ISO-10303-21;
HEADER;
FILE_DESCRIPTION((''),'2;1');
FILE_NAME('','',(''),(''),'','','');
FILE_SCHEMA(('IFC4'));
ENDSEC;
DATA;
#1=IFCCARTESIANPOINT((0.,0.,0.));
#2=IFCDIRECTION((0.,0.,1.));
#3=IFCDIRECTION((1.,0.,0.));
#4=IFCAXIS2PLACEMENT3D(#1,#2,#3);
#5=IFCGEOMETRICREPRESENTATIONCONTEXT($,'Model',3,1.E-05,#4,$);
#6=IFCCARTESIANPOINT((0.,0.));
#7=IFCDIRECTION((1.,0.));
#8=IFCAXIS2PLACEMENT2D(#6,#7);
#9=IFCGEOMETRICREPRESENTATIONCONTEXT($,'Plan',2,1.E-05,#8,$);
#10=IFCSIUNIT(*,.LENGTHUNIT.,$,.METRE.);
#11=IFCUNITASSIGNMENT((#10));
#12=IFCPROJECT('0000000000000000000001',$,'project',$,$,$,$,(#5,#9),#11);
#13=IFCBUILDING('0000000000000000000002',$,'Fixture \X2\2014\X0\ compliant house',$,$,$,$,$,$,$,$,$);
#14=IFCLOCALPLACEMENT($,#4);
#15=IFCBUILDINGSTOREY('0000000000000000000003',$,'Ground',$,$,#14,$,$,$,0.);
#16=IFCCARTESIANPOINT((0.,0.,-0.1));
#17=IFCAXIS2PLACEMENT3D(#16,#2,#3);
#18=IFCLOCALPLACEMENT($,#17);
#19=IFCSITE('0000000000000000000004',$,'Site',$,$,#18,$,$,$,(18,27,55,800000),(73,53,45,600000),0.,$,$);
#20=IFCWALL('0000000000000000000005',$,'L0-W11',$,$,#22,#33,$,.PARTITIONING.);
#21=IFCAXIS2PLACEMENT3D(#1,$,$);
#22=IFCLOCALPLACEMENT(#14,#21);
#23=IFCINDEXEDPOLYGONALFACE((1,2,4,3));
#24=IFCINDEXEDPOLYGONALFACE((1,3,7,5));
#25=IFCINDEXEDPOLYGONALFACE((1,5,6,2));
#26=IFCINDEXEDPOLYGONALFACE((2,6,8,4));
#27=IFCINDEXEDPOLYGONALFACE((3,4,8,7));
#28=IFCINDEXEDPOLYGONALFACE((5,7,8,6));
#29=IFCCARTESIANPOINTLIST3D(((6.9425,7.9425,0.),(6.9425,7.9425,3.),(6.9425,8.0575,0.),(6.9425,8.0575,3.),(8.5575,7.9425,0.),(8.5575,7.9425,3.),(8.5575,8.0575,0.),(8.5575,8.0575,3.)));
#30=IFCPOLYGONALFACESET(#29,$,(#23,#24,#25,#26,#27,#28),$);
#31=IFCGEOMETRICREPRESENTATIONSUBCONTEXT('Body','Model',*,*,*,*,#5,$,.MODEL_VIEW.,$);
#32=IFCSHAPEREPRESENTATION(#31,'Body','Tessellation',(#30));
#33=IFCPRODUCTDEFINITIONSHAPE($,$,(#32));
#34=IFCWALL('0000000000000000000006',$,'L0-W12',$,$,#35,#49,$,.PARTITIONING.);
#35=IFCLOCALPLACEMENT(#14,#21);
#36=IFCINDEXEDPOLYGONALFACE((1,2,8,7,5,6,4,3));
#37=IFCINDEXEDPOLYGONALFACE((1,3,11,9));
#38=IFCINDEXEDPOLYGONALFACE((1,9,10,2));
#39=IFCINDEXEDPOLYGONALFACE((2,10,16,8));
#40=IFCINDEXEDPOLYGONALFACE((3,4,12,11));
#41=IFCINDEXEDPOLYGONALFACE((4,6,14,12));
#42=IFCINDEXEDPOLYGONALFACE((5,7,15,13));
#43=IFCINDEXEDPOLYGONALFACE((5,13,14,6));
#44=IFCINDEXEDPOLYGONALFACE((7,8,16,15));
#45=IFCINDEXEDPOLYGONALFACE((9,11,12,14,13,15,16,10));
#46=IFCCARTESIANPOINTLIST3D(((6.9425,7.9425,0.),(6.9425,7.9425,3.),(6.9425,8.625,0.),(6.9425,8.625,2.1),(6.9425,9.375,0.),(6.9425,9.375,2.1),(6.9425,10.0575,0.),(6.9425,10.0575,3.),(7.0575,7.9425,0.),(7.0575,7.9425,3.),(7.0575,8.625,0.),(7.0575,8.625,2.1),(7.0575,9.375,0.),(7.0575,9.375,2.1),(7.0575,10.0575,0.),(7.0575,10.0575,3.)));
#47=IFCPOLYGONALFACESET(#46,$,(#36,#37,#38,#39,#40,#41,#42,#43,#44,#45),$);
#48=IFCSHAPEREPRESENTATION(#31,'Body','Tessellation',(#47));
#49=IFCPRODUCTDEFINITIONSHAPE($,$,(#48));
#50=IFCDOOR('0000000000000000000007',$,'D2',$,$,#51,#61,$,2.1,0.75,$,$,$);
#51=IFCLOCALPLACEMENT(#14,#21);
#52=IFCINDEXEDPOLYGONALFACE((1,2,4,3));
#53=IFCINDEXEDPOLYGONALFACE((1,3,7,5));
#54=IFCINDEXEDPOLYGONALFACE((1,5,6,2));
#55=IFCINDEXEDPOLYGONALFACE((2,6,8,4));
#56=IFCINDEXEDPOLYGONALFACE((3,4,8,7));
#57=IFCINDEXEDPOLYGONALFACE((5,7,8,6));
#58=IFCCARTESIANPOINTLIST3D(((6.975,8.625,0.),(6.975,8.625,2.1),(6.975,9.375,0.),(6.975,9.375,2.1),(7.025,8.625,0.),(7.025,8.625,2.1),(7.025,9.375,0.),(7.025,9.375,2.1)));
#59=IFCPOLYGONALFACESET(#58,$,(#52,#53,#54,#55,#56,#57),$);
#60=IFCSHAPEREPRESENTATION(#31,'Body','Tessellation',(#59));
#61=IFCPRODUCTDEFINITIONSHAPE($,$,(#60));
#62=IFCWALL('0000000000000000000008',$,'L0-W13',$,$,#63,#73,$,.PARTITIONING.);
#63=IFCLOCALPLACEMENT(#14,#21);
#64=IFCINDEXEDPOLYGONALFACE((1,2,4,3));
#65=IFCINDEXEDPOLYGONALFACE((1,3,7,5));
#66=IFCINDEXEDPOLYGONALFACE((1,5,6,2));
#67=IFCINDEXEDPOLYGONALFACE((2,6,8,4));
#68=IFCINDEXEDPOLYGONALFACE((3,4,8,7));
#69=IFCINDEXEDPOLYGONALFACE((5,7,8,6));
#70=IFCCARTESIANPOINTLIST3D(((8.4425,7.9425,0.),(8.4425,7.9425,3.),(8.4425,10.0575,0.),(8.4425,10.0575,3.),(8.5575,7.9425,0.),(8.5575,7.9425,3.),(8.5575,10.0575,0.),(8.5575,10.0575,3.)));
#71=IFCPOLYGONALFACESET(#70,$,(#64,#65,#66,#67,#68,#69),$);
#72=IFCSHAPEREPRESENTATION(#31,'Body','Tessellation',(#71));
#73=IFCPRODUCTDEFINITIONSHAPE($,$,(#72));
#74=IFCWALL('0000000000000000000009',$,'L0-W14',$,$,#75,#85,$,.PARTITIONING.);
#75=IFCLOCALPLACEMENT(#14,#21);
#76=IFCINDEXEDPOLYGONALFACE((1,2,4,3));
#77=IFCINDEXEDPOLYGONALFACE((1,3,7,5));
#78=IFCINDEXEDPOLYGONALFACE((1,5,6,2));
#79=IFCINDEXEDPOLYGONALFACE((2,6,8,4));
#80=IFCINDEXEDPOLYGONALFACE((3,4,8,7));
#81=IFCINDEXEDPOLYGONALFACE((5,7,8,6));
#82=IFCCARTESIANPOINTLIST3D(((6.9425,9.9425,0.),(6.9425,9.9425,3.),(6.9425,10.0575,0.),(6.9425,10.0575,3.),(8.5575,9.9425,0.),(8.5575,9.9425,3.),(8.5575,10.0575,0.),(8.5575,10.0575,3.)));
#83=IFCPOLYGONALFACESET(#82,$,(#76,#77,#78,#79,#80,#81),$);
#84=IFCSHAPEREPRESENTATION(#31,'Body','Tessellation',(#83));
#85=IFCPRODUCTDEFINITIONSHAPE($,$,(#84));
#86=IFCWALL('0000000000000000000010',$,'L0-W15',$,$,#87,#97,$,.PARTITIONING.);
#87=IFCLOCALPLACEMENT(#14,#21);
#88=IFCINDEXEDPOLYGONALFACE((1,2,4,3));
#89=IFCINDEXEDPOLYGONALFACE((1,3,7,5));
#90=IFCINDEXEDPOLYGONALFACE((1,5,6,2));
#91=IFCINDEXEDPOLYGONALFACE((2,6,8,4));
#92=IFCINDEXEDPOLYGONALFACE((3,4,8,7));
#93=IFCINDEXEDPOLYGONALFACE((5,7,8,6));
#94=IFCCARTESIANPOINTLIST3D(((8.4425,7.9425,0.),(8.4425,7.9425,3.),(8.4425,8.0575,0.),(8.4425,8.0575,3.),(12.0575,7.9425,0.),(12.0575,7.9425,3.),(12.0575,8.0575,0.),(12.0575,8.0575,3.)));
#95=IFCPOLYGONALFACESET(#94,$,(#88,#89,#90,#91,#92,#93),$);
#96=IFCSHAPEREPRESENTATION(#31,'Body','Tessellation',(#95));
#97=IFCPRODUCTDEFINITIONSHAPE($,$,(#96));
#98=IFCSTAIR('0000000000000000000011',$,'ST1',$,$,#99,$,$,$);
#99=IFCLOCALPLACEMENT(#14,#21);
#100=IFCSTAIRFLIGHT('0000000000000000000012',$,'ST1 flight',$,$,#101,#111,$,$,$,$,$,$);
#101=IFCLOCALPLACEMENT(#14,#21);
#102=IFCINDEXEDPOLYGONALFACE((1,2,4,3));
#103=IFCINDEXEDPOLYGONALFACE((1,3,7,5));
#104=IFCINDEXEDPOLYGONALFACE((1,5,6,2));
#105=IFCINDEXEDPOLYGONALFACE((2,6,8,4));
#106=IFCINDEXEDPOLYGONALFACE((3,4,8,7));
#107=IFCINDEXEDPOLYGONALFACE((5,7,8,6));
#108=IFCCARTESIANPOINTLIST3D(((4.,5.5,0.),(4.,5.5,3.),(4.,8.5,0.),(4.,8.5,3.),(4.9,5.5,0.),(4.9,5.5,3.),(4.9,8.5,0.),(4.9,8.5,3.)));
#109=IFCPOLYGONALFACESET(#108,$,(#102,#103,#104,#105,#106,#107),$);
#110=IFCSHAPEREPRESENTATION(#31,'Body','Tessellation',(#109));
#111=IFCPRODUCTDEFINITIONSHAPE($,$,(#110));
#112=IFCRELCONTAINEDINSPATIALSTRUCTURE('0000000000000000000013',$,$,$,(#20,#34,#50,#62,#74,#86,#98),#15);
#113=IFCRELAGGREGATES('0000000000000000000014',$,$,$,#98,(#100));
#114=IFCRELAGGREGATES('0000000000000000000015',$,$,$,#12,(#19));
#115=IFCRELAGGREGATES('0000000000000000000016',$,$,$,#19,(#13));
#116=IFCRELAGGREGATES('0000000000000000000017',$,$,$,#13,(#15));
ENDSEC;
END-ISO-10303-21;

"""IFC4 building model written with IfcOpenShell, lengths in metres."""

from ifc_helpers import new_model, si_unit, frame, origin_with_axes, origin_2d_with_axis, place, context, subcontext, project, spatial, line, indexed_curve, outline, extrude, element, fill, aggregate, save


model = new_model("IFC4")

# Units and contexts
model_context = context("Model", 3, precision=1e-05, world=origin_with_axes())
plan_context = context("Plan", 2, precision=1e-05, world=origin_2d_with_axis())
body_context = subcontext(model_context, "Body", "Model", "MODEL_VIEW")
ifc_project = project(units=[si_unit("LENGTHUNIT", "METRE")], contexts=[model_context, plan_context])

# Site, building, storey
site_placement = place(None, frame((0.0, 0.0, -0.1), z_axis=(0.0, 0.0, 1.0), x_axis=(1.0, 0.0, 0.0)))
site = spatial("IfcSite", under=ifc_project, at=site_placement, Name="Site", RefLatitude=(18, 27, 55, 800000), RefLongitude=(73, 53, 45, 600000), RefElevation=0.0)
building = spatial("IfcBuilding", under=site, Name="Fixture — compliant house")
storey_placement = place(None, origin_with_axes())
storey = spatial("IfcBuildingStorey", under=building, at=storey_placement, Name="Ground", Elevation=0.0)

# Wall
wall_1_placement = place(storey_placement, origin_with_axes())
element("IfcWall", 1, at=wall_1_placement, inside=storey, Name="L0-W11", PredefinedType="PARTITIONING", context=body_context, shape_type="SweptSolid", body=[
    extrude(outline(indexed_curve([(8.5575, 7.9425), (6.9425, 7.9425), (6.9425, 8.0575), (8.5575, 8.0575)], segments=[line(1, 2, 3, 4, 1)])), origin_with_axes(), (0.0, 0.0, 1.0), 3.0),
])

# Wall, opening, door
wall_2_placement = place(storey_placement, origin_with_axes())
wall_2 = element("IfcWall", 2, at=wall_2_placement, inside=storey, Name="L0-W12", PredefinedType="PARTITIONING", context=body_context, shape_type="SweptSolid", body=[
    extrude(outline(indexed_curve([(6.9425, 7.9425), (6.9425, 10.0575), (7.0575, 10.0575), (7.0575, 7.9425)], segments=[line(1, 2, 3, 4, 1)])), origin_with_axes(), (0.0, 0.0, 1.0), 3.0),
])
opening_1_placement = place(wall_2_placement, origin_with_axes())
opening_1 = element("IfcOpeningElement", 3, at=opening_1_placement, cuts=wall_2, context=body_context, shape_type="SweptSolid", body=[
    extrude(outline(indexed_curve([(6.8925, 8.625), (6.8925, 9.375), (7.1075, 9.375), (7.1075, 8.625)], segments=[line(1, 2, 3, 4, 1)])), origin_with_axes(), (0.0, 0.0, 1.0), 2.1),
])
door_1_placement = place(storey_placement, origin_with_axes())
door_1 = element("IfcDoor", 4, at=door_1_placement, inside=storey, Name="D2", OverallHeight=2.1, OverallWidth=0.75, context=body_context, shape_type="SweptSolid", body=[
    extrude(outline(indexed_curve([(6.975, 8.625), (6.975, 9.375), (7.025, 9.375), (7.025, 8.625)], segments=[line(1, 2, 3, 4, 1)])), origin_with_axes(), (0.0, 0.0, 1.0), 2.1),
])
fill(opening_1, door_1)

# Walls
wall_3_placement = place(storey_placement, origin_with_axes())
element("IfcWall", 5, at=wall_3_placement, inside=storey, Name="L0-W13", PredefinedType="PARTITIONING", context=body_context, shape_type="SweptSolid", body=[
    extrude(outline(indexed_curve([(8.4425, 7.9425), (8.4425, 10.0575), (8.5575, 10.0575), (8.5575, 7.9425)], segments=[line(1, 2, 3, 4, 1)])), origin_with_axes(), (0.0, 0.0, 1.0), 3.0),
])
wall_4_placement = place(storey_placement, origin_with_axes())
element("IfcWall", 6, at=wall_4_placement, inside=storey, Name="L0-W14", PredefinedType="PARTITIONING", context=body_context, shape_type="SweptSolid", body=[
    extrude(outline(indexed_curve([(8.5575, 9.9425), (6.9425, 9.9425), (6.9425, 10.0575), (8.5575, 10.0575)], segments=[line(1, 2, 3, 4, 1)])), origin_with_axes(), (0.0, 0.0, 1.0), 3.0),
])
wall_5_placement = place(storey_placement, origin_with_axes())
element("IfcWall", 7, at=wall_5_placement, inside=storey, Name="L0-W15", PredefinedType="PARTITIONING", context=body_context, shape_type="SweptSolid", body=[
    extrude(outline(indexed_curve([(12.0575, 7.9425), (8.4425, 7.9425), (8.4425, 8.0575), (12.0575, 8.0575)], segments=[line(1, 2, 3, 4, 1)])), origin_with_axes(), (0.0, 0.0, 1.0), 3.0),
])

# Stair, stair flight
stair = element("IfcStair", 8, inside=storey, Name="ST1")
stair_flight_placement = place(None, frame((4.0, 5.5, 0.0), z_axis=(0.0, 0.0, 1.0), x_axis=(1.0, 0.0, 0.0)))
stair_flight = element("IfcStairFlight", 9, at=stair_flight_placement, Name="ST1 flight", context=body_context, shape_type="SweptSolid", body=[
    extrude(outline(indexed_curve([(0.0, 0.0), (0.9, 0.0), (0.9, 3.0), (0.0, 3.0)], segments=[line(1, 2, 3, 4, 1)])), origin_with_axes(), (0.0, 0.0, 1.0), 3.0),
])
aggregate(stair, [stair_flight])

save(model, "model.ifc")
